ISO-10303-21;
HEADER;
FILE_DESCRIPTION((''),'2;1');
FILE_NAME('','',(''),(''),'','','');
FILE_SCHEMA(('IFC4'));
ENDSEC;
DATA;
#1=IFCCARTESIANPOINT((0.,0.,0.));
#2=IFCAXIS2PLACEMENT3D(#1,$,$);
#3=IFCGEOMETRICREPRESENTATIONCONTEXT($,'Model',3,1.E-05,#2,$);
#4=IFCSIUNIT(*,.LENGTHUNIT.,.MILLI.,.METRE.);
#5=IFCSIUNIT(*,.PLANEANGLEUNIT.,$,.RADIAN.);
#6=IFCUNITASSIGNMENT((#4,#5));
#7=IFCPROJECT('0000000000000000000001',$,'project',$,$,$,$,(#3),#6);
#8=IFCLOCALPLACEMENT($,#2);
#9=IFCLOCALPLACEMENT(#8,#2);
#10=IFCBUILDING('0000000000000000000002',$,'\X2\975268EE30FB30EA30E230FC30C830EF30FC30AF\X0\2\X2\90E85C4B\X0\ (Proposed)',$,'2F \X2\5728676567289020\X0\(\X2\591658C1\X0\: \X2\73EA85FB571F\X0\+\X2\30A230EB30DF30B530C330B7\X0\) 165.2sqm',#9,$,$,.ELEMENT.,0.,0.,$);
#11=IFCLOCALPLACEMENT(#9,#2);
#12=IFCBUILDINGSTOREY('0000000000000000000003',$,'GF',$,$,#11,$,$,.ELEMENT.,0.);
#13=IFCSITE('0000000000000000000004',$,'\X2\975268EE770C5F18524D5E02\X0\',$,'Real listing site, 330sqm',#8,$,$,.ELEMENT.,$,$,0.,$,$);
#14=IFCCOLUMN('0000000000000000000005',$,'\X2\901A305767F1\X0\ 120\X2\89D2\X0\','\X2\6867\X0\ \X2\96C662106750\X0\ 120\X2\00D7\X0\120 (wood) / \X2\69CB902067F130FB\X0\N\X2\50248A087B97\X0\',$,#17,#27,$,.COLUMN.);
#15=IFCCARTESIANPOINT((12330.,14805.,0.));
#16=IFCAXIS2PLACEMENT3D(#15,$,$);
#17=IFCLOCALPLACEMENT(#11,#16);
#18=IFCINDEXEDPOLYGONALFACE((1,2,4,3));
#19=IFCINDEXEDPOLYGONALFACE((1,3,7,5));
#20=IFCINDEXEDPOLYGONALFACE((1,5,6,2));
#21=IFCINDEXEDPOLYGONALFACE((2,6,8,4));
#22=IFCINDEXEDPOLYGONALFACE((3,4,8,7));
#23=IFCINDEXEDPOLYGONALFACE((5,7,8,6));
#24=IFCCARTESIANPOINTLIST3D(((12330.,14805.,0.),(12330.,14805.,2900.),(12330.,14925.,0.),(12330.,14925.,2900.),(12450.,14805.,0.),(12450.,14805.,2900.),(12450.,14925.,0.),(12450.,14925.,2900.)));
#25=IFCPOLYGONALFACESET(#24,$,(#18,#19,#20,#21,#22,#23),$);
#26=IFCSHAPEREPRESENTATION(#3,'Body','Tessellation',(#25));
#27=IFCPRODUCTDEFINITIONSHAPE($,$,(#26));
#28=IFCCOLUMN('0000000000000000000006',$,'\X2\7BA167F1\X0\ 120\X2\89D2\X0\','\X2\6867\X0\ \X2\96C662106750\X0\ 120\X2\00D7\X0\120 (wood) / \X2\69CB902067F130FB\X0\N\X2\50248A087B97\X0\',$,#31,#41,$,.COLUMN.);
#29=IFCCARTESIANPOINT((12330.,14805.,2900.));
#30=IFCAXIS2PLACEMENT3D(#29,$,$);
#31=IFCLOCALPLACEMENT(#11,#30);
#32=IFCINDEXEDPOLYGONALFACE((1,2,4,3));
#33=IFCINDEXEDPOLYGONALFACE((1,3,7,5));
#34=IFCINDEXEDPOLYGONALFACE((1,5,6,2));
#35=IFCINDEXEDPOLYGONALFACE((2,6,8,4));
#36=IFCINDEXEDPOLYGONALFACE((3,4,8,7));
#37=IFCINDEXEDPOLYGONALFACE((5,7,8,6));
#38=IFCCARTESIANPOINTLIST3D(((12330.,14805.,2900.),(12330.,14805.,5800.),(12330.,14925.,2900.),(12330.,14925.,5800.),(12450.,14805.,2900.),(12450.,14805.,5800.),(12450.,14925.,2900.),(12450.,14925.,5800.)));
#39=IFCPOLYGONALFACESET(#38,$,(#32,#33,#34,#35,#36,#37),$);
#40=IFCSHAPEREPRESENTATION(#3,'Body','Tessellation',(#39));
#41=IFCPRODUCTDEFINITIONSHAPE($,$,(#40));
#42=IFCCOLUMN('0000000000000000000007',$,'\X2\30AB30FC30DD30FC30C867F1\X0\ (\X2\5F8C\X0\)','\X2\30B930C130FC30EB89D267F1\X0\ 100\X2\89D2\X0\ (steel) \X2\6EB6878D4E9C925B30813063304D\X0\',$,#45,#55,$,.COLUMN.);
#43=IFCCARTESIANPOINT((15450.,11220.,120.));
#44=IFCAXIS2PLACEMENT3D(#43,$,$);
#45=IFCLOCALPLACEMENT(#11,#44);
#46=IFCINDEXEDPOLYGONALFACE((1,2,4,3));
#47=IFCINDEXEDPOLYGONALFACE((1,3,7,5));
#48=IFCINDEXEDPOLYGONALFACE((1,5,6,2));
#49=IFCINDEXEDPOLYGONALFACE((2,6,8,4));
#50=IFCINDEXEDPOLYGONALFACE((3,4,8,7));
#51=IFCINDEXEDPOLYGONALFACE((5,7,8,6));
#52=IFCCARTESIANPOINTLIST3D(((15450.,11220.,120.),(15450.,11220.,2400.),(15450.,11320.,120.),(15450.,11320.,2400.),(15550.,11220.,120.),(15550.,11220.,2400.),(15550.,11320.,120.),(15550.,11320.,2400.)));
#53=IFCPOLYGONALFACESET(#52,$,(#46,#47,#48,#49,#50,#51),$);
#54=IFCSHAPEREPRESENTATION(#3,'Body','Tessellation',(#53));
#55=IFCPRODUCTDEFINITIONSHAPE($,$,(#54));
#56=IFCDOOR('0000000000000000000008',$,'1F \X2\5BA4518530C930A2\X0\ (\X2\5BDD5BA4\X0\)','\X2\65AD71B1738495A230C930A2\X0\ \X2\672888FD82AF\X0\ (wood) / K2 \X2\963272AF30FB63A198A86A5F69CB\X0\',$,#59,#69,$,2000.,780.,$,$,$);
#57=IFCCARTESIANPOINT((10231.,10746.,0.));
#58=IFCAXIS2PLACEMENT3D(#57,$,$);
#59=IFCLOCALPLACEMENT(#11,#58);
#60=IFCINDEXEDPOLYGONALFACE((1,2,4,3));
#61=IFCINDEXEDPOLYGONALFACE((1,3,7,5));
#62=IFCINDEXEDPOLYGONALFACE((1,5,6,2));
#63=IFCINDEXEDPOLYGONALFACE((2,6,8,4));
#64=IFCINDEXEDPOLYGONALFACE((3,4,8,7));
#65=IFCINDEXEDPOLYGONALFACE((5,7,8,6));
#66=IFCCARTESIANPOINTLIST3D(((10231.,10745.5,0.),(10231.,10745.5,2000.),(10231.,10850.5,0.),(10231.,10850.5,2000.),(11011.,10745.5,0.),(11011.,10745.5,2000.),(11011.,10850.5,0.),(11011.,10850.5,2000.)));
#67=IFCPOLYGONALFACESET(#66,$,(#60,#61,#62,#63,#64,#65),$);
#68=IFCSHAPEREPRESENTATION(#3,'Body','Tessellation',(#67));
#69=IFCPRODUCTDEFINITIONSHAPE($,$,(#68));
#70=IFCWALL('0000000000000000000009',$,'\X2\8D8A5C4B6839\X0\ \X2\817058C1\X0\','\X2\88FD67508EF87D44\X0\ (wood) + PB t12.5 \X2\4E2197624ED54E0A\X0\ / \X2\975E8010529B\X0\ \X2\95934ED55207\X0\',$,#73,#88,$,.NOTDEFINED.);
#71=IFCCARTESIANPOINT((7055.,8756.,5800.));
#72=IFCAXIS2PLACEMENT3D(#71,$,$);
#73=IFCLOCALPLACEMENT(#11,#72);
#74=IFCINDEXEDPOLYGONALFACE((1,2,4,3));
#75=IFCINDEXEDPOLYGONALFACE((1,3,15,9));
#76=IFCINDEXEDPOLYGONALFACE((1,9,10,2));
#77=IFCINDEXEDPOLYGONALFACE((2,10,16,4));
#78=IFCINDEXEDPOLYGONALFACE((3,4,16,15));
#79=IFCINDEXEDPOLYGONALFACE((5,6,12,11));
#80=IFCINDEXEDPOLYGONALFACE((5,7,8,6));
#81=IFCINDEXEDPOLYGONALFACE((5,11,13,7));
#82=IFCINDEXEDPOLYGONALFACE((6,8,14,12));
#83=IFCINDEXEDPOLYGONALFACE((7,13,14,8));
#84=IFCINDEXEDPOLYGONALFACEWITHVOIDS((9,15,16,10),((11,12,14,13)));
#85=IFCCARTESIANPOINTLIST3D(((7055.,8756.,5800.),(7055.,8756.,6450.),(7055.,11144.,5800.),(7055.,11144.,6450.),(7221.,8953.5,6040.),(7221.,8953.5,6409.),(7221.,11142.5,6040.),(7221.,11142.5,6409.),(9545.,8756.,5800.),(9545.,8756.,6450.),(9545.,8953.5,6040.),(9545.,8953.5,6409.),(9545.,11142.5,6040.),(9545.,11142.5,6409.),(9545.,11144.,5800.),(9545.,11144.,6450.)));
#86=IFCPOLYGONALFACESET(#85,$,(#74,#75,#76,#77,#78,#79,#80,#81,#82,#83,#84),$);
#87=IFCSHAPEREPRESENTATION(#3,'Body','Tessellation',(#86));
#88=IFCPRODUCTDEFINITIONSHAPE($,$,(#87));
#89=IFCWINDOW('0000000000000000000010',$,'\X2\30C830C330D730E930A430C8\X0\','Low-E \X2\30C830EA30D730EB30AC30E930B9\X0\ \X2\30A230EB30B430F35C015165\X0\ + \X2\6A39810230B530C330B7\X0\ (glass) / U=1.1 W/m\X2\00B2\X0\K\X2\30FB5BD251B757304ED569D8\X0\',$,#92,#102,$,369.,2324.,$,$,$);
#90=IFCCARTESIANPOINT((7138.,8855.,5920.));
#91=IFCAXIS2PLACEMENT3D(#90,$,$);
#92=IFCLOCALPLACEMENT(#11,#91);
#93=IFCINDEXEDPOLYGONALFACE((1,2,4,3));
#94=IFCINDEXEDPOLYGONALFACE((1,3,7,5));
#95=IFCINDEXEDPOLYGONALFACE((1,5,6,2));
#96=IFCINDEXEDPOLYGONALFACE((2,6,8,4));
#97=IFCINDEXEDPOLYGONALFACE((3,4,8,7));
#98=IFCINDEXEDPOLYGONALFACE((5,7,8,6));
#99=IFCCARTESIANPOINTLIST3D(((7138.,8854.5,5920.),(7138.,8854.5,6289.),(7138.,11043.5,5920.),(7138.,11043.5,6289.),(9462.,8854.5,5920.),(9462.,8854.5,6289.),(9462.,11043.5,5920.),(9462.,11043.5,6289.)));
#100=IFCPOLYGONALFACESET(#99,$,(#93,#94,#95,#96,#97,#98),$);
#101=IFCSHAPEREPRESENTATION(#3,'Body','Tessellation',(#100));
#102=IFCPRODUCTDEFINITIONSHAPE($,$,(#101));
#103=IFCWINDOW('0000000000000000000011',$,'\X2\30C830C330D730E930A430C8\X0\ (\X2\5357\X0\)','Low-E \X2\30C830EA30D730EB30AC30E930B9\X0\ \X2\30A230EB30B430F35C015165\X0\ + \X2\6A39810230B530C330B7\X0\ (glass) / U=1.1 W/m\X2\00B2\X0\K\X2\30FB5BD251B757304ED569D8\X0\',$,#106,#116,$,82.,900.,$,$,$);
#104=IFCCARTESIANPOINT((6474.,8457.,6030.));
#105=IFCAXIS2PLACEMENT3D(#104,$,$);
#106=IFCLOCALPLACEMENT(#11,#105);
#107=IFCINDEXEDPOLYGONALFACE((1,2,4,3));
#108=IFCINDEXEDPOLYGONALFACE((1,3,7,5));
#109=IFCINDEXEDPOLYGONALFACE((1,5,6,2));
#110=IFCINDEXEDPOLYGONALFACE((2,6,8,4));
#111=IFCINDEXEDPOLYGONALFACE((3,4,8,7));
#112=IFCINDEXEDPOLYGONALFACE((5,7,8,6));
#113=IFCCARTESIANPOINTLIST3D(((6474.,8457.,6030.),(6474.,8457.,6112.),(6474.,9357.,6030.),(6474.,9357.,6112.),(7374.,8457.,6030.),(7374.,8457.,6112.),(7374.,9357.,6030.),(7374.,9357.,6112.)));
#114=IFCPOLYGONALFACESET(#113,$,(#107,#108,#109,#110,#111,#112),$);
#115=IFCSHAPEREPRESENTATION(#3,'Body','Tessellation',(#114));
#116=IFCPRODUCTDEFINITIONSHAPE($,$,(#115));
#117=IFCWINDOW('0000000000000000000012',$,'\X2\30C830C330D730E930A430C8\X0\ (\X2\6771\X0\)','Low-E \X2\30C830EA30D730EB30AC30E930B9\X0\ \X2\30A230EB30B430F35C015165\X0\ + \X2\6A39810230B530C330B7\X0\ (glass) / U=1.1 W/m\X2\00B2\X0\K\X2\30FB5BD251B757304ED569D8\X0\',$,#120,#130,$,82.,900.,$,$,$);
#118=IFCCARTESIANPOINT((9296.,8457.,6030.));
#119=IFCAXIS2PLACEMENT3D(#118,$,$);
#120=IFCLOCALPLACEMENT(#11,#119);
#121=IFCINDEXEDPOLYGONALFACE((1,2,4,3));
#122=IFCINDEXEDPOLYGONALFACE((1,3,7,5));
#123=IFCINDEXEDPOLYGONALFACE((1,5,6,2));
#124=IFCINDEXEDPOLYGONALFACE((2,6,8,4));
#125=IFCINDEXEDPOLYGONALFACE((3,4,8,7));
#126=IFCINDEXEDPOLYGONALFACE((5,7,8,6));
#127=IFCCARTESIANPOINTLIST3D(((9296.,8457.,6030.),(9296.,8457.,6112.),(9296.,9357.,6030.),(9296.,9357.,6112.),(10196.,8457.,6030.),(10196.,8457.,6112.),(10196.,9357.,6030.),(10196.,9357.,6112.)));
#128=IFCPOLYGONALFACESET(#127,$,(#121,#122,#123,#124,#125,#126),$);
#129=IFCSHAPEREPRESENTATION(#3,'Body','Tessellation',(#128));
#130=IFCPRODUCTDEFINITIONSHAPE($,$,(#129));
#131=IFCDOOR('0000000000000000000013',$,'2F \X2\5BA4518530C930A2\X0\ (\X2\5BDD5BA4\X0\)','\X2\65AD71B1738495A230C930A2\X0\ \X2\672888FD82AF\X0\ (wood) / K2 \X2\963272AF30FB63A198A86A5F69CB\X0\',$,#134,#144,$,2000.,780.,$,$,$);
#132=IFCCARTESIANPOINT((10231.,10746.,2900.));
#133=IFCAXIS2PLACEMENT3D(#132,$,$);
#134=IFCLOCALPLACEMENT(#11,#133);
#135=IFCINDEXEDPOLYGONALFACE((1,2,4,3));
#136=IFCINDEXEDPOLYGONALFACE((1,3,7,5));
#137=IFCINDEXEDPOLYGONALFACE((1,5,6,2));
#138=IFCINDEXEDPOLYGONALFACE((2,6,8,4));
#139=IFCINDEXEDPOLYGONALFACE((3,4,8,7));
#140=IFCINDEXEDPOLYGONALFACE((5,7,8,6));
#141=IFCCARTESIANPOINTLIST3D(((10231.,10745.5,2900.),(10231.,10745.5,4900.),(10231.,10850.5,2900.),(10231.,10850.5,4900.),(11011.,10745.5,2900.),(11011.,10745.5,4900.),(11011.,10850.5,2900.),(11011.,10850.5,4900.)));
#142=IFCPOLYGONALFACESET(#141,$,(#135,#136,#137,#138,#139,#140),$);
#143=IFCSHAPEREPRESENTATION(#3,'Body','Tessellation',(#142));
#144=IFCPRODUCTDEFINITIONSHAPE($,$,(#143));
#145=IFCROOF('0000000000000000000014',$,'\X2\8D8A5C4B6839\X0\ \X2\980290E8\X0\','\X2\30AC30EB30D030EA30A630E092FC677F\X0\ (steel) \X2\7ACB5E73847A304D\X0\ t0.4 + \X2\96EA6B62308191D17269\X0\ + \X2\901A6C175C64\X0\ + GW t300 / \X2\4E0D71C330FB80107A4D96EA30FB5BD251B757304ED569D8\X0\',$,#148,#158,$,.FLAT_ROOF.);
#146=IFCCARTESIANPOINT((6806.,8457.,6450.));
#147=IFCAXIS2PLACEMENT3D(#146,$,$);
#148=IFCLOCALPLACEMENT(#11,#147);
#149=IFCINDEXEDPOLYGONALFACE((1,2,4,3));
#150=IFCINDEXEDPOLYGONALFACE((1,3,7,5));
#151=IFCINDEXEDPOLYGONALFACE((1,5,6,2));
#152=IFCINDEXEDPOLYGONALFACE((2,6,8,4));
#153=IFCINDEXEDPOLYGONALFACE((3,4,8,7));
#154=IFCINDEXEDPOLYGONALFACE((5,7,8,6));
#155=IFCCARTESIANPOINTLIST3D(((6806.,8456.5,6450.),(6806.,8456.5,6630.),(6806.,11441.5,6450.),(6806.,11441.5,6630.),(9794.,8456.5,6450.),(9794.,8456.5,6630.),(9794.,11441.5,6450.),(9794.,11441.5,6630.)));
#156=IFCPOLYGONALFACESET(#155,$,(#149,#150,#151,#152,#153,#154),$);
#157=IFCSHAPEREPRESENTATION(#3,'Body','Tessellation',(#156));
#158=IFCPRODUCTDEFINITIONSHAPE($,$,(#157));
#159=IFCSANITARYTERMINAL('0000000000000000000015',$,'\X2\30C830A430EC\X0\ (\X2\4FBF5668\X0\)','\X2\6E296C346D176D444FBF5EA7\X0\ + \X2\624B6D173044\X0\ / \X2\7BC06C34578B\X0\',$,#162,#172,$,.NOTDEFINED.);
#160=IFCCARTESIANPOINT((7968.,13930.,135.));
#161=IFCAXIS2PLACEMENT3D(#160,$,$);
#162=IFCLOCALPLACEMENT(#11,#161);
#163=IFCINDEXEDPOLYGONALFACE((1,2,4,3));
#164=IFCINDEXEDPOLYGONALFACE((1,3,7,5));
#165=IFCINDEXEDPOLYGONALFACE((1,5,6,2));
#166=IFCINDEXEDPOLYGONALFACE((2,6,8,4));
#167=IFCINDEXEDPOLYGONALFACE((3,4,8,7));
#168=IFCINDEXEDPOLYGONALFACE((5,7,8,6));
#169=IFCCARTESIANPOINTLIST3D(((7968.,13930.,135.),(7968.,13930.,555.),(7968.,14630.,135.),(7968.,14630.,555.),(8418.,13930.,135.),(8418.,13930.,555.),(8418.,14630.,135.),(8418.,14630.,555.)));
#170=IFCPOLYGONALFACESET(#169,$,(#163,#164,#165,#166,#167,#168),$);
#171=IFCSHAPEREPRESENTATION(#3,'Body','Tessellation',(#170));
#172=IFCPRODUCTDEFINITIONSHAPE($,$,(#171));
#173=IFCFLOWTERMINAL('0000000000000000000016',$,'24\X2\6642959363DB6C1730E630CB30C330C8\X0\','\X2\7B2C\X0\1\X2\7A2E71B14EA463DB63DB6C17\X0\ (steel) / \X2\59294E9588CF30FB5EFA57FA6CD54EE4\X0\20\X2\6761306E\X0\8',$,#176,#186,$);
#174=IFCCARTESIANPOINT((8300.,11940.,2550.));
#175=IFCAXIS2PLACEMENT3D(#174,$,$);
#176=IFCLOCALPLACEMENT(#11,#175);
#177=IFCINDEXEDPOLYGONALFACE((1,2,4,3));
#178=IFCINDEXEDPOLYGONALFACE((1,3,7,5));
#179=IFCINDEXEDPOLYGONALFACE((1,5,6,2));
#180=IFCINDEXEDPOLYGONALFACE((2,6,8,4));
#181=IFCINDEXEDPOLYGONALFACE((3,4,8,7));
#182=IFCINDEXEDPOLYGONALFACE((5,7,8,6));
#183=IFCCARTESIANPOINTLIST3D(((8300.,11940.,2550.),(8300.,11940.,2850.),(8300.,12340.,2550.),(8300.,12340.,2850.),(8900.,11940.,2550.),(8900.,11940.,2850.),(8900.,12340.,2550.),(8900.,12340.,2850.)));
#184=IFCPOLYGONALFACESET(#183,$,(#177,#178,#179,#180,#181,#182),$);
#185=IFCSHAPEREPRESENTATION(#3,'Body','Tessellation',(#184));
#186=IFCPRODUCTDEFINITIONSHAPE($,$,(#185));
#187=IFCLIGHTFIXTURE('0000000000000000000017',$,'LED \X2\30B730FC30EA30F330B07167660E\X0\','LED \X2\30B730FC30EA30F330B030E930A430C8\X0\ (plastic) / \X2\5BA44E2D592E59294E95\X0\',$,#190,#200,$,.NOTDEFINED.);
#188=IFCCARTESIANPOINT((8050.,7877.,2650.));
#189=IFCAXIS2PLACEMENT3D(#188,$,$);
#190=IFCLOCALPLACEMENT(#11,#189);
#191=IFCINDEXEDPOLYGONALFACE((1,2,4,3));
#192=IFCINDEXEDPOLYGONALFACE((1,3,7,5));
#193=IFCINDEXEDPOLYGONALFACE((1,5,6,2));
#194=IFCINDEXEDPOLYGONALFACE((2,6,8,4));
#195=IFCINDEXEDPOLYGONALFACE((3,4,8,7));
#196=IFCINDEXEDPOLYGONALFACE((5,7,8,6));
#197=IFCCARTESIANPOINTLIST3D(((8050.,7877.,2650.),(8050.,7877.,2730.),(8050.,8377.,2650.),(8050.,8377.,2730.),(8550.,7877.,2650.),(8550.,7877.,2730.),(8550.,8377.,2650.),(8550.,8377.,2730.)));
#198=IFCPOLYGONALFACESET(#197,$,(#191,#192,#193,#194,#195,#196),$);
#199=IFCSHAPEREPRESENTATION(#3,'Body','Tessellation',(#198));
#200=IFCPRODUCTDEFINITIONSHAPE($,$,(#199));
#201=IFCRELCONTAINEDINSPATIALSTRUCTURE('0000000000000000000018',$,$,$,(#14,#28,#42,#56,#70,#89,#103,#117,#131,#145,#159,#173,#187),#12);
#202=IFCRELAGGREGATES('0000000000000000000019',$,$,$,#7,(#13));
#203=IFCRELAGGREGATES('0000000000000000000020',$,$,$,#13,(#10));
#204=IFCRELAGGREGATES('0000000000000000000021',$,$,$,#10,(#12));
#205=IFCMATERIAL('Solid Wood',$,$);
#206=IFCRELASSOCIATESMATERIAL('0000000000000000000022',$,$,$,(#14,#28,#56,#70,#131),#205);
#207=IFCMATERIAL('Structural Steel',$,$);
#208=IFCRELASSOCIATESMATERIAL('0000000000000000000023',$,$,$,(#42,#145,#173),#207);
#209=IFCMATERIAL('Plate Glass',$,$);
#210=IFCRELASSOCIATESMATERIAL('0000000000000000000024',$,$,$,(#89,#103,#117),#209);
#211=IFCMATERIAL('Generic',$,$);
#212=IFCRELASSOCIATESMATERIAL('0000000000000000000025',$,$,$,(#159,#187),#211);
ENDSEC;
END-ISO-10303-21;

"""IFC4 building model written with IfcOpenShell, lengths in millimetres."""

from ifc_helpers import new_model, si_unit, frame, frame_2d, origin, place, context, project, spatial, rectangle, extrude, material, element, fill, save


model = new_model("IFC4")

# Units and contexts
model_context = context("Model", 3, precision=1e-05, world=origin())
ifc_project = project(units=[si_unit("LENGTHUNIT", "METRE", prefix="MILLI"), si_unit("PLANEANGLEUNIT", "RADIAN")], contexts=[model_context])

# Site, building, storey
site_placement = place(None, origin())
site = spatial("IfcSite", under=ifc_project, at=site_placement, Name="青森県弘前市", ObjectType="Real listing site, 330sqm", CompositionType="ELEMENT", RefElevation=0.0)
building_placement = place(site_placement, origin())
building = spatial("IfcBuilding", under=site, at=building_placement, Name="青森・リモートワーク2部屋 (Proposed)", ObjectType="2F 在来木造(外壁: 珪藻土+アルミサッシ) 165.2sqm", CompositionType="ELEMENT", ElevationOfRefHeight=0.0, ElevationOfTerrain=0.0)
storey_placement = place(building_placement, origin())
storey = spatial("IfcBuildingStorey", under=building, at=storey_placement, Name="GF", CompositionType="ELEMENT", Elevation=0.0)

# Columns
ifc_material_1 = material(Name="Solid Wood")
column_1_placement = place(storey_placement, frame((12330.0, 14805.0, 0.0)))
element("IfcColumn", 1, at=column_1_placement, inside=storey, material=ifc_material_1, Name="通し柱 120角", Description="桧 集成材 120×120 (wood) / 構造柱・N値計算", PredefinedType="COLUMN", context=model_context, shape_type="SweptSolid", body=[
    extrude(rectangle(XDim=120.0, YDim=120.0, at=frame_2d((60.0, 60.0))), frame((12330.0, 14805.0, 0.0)), (0.0, 0.0, 1.0), 2900.0),
])
column_2_placement = place(storey_placement, frame((12330.0, 14805.0, 2900.0)))
element("IfcColumn", 2, at=column_2_placement, inside=storey, material=ifc_material_1, Name="管柱 120角", Description="桧 集成材 120×120 (wood) / 構造柱・N値計算", PredefinedType="COLUMN", context=model_context, shape_type="SweptSolid", body=[
    extrude(rectangle(XDim=120.0, YDim=120.0, at=frame_2d((60.0, 60.0))), frame((12330.0, 14805.0, 2900.0)), (0.0, 0.0, 1.0), 2900.0),
])
ifc_material_2 = material(Name="Structural Steel")
column_3_placement = place(storey_placement, frame((15450.0, 11220.0, 120.0)))
element("IfcColumn", 3, at=column_3_placement, inside=storey, material=ifc_material_2, Name="カーポート柱 (後)", Description="スチール角柱 100角 (steel) 溶融亜鉛めっき", PredefinedType="COLUMN", context=model_context, shape_type="SweptSolid", body=[
    extrude(rectangle(XDim=100.0, YDim=100.0, at=frame_2d((50.0, 50.0))), frame((15450.0, 11220.0, 120.0)), (0.0, 0.0, 1.0), 2280.0),
])

# Door
door_1_placement = place(storey_placement, frame((10231.0, 10746.0, 0.0)))
element("IfcDoor", 4, at=door_1_placement, inside=storey, material=ifc_material_1, Name="1F 室内ドア (寝室)", Description="断熱玄関ドア 木製芯 (wood) / K2 防犯・採風機構", OverallHeight=2000.0, OverallWidth=780.0, context=model_context, shape_type="SweptSolid", body=[
    extrude(rectangle(XDim=780.0, YDim=105.0, at=frame_2d((390.0, 52.0))), frame((10231.0, 10746.0, 0.0)), (0.0, 0.0, 1.0), 2000.0),
])

# Wall, openings, windows
wall_1_placement = place(storey_placement, frame((7055.0, 8756.0, 5800.0)))
wall_1 = element("IfcWall", 5, at=wall_1_placement, inside=storey, material=ifc_material_1, Name="越屋根 腰壁", Description="製材軸組 (wood) + PB t12.5 両面仕上 / 非耐力 間仕切", PredefinedType="NOTDEFINED", context=model_context, shape_type="SweptSolid", body=[
    extrude(rectangle(XDim=2490.0, YDim=2388.0, at=frame_2d((1245.0, 1194.0))), frame((7055.0, 8756.0, 5800.0)), (0.0, 0.0, 1.0), 650.0),
])
opening_1_placement = place(storey_placement, frame((7138.0, 8855.0, 5920.0)))
opening_1 = element("IfcOpeningElement", 6, at=opening_1_placement, cuts=wall_1, PredefinedType="NOTDEFINED", context=model_context, shape_type="SweptSolid", body=[
    extrude(rectangle(XDim=2324.0, YDim=2189.0, at=frame_2d((1162.0, 1094.0))), frame((7138.0, 8855.0, 5920.0)), (0.0, 0.0, 1.0), 369.0),
])
opening_2_placement = place(storey_placement, frame((6474.0, 8457.0, 6030.0)))
opening_2 = element("IfcOpeningElement", 7, at=opening_2_placement, cuts=wall_1, PredefinedType="NOTDEFINED", context=model_context, shape_type="SweptSolid", body=[
    extrude(rectangle(XDim=900.0, YDim=900.0, at=frame_2d((450.0, 450.0))), frame((6474.0, 8457.0, 6030.0)), (0.0, 0.0, 1.0), 82.0),
])
opening_3_placement = place(storey_placement, frame((9296.0, 8457.0, 6030.0)))
opening_3 = element("IfcOpeningElement", 8, at=opening_3_placement, cuts=wall_1, PredefinedType="NOTDEFINED", context=model_context, shape_type="SweptSolid", body=[
    extrude(rectangle(XDim=900.0, YDim=900.0, at=frame_2d((450.0, 450.0))), frame((9296.0, 8457.0, 6030.0)), (0.0, 0.0, 1.0), 82.0),
])
ifc_material_3 = material(Name="Plate Glass")
window_1_placement = place(storey_placement, frame((7138.0, 8855.0, 5920.0)))
window_1 = element("IfcWindow", 9, at=window_1_placement, inside=storey, material=ifc_material_3, Name="トップライト", Description="Low-E トリプルガラス アルゴン封入 + 樹脂サッシ (glass) / U=1.1 W/m²K・寒冷地仕様", OverallHeight=369.0, OverallWidth=2324.0, context=model_context, shape_type="SweptSolid", body=[
    extrude(rectangle(XDim=2324.0, YDim=2189.0, at=frame_2d((1162.0, 1094.0))), frame((7138.0, 8855.0, 5920.0)), (0.0, 0.0, 1.0), 369.0),
])
fill(opening_1, window_1)
window_2_placement = place(storey_placement, frame((6474.0, 8457.0, 6030.0)))
window_2 = element("IfcWindow", 10, at=window_2_placement, inside=storey, material=ifc_material_3, Name="トップライト (南)", Description="Low-E トリプルガラス アルゴン封入 + 樹脂サッシ (glass) / U=1.1 W/m²K・寒冷地仕様", OverallHeight=82.0, OverallWidth=900.0, context=model_context, shape_type="SweptSolid", body=[
    extrude(rectangle(XDim=900.0, YDim=900.0, at=frame_2d((450.0, 450.0))), frame((6474.0, 8457.0, 6030.0)), (0.0, 0.0, 1.0), 82.0),
])
fill(opening_2, window_2)
window_3_placement = place(storey_placement, frame((9296.0, 8457.0, 6030.0)))
window_3 = element("IfcWindow", 11, at=window_3_placement, inside=storey, material=ifc_material_3, Name="トップライト (東)", Description="Low-E トリプルガラス アルゴン封入 + 樹脂サッシ (glass) / U=1.1 W/m²K・寒冷地仕様", OverallHeight=82.0, OverallWidth=900.0, context=model_context, shape_type="SweptSolid", body=[
    extrude(rectangle(XDim=900.0, YDim=900.0, at=frame_2d((450.0, 450.0))), frame((9296.0, 8457.0, 6030.0)), (0.0, 0.0, 1.0), 82.0),
])
fill(opening_3, window_3)

# Door
door_2_placement = place(storey_placement, frame((10231.0, 10746.0, 2900.0)))
element("IfcDoor", 12, at=door_2_placement, inside=storey, material=ifc_material_1, Name="2F 室内ドア (寝室)", Description="断熱玄関ドア 木製芯 (wood) / K2 防犯・採風機構", OverallHeight=2000.0, OverallWidth=780.0, context=model_context, shape_type="SweptSolid", body=[
    extrude(rectangle(XDim=780.0, YDim=105.0, at=frame_2d((390.0, 52.0))), frame((10231.0, 10746.0, 2900.0)), (0.0, 0.0, 1.0), 2000.0),
])

# Roof
roof_placement = place(storey_placement, frame((6806.0, 8457.0, 6450.0)))
element("IfcRoof", 13, at=roof_placement, inside=storey, material=ifc_material_2, Name="越屋根 頂部", Description="ガルバリウム鋼板 (steel) 立平葺き t0.4 + 雪止め金物 + 通気層 + GW t300 / 不燃・耐積雪・寒冷地仕様", PredefinedType="FLAT_ROOF", context=model_context, shape_type="SweptSolid", body=[
    extrude(rectangle(XDim=2988.0, YDim=2985.0, at=frame_2d((1494.0, 1492.0))), frame((6806.0, 8457.0, 6450.0)), (0.0, 0.0, 1.0), 180.0),
])

# Sanitary terminal
ifc_material_4 = material(Name="Generic")
sanitary_terminal_placement = place(storey_placement, frame((7968.0, 13930.0, 135.0)))
element("IfcSanitaryTerminal", 14, at=sanitary_terminal_placement, inside=storey, material=ifc_material_4, Name="トイレ (便器)", Description="温水洗浄便座 + 手洗い / 節水型", PredefinedType="NOTDEFINED", context=model_context, shape_type="SweptSolid", body=[
    extrude(rectangle(XDim=450.0, YDim=700.0, at=frame_2d((225.0, 350.0))), frame((7968.0, 13930.0, 135.0)), (0.0, 0.0, 1.0), 420.0),
])

# Flow terminal
flow_terminal_placement = place(storey_placement, frame((8300.0, 11940.0, 2550.0)))
element("IfcFlowTerminal", 15, at=flow_terminal_placement, inside=storey, material=ifc_material_2, Name="24時間換気ユニット", Description="第1種熱交換換気 (steel) / 天井裏・建基法令20条の8", context=model_context, shape_type="SweptSolid", body=[
    extrude(rectangle(XDim=600.0, YDim=400.0, at=frame_2d((300.0, 200.0))), frame((8300.0, 11940.0, 2550.0)), (0.0, 0.0, 1.0), 300.0),
])

# Light fixture
light_fixture_1_placement = place(storey_placement, frame((8050.0, 7877.0, 2650.0)))
element("IfcLightFixture", 16, at=light_fixture_1_placement, inside=storey, material=ifc_material_4, Name="LED シーリング照明", Description="LED シーリングライト (plastic) / 室中央天井", PredefinedType="NOTDEFINED", context=model_context, shape_type="SweptSolid", body=[
    extrude(rectangle(XDim=500.0, YDim=500.0, at=frame_2d((250.0, 250.0))), frame((8050.0, 7877.0, 2650.0)), (0.0, 0.0, 1.0), 80.0),
])

save(model, "model.ifc")
